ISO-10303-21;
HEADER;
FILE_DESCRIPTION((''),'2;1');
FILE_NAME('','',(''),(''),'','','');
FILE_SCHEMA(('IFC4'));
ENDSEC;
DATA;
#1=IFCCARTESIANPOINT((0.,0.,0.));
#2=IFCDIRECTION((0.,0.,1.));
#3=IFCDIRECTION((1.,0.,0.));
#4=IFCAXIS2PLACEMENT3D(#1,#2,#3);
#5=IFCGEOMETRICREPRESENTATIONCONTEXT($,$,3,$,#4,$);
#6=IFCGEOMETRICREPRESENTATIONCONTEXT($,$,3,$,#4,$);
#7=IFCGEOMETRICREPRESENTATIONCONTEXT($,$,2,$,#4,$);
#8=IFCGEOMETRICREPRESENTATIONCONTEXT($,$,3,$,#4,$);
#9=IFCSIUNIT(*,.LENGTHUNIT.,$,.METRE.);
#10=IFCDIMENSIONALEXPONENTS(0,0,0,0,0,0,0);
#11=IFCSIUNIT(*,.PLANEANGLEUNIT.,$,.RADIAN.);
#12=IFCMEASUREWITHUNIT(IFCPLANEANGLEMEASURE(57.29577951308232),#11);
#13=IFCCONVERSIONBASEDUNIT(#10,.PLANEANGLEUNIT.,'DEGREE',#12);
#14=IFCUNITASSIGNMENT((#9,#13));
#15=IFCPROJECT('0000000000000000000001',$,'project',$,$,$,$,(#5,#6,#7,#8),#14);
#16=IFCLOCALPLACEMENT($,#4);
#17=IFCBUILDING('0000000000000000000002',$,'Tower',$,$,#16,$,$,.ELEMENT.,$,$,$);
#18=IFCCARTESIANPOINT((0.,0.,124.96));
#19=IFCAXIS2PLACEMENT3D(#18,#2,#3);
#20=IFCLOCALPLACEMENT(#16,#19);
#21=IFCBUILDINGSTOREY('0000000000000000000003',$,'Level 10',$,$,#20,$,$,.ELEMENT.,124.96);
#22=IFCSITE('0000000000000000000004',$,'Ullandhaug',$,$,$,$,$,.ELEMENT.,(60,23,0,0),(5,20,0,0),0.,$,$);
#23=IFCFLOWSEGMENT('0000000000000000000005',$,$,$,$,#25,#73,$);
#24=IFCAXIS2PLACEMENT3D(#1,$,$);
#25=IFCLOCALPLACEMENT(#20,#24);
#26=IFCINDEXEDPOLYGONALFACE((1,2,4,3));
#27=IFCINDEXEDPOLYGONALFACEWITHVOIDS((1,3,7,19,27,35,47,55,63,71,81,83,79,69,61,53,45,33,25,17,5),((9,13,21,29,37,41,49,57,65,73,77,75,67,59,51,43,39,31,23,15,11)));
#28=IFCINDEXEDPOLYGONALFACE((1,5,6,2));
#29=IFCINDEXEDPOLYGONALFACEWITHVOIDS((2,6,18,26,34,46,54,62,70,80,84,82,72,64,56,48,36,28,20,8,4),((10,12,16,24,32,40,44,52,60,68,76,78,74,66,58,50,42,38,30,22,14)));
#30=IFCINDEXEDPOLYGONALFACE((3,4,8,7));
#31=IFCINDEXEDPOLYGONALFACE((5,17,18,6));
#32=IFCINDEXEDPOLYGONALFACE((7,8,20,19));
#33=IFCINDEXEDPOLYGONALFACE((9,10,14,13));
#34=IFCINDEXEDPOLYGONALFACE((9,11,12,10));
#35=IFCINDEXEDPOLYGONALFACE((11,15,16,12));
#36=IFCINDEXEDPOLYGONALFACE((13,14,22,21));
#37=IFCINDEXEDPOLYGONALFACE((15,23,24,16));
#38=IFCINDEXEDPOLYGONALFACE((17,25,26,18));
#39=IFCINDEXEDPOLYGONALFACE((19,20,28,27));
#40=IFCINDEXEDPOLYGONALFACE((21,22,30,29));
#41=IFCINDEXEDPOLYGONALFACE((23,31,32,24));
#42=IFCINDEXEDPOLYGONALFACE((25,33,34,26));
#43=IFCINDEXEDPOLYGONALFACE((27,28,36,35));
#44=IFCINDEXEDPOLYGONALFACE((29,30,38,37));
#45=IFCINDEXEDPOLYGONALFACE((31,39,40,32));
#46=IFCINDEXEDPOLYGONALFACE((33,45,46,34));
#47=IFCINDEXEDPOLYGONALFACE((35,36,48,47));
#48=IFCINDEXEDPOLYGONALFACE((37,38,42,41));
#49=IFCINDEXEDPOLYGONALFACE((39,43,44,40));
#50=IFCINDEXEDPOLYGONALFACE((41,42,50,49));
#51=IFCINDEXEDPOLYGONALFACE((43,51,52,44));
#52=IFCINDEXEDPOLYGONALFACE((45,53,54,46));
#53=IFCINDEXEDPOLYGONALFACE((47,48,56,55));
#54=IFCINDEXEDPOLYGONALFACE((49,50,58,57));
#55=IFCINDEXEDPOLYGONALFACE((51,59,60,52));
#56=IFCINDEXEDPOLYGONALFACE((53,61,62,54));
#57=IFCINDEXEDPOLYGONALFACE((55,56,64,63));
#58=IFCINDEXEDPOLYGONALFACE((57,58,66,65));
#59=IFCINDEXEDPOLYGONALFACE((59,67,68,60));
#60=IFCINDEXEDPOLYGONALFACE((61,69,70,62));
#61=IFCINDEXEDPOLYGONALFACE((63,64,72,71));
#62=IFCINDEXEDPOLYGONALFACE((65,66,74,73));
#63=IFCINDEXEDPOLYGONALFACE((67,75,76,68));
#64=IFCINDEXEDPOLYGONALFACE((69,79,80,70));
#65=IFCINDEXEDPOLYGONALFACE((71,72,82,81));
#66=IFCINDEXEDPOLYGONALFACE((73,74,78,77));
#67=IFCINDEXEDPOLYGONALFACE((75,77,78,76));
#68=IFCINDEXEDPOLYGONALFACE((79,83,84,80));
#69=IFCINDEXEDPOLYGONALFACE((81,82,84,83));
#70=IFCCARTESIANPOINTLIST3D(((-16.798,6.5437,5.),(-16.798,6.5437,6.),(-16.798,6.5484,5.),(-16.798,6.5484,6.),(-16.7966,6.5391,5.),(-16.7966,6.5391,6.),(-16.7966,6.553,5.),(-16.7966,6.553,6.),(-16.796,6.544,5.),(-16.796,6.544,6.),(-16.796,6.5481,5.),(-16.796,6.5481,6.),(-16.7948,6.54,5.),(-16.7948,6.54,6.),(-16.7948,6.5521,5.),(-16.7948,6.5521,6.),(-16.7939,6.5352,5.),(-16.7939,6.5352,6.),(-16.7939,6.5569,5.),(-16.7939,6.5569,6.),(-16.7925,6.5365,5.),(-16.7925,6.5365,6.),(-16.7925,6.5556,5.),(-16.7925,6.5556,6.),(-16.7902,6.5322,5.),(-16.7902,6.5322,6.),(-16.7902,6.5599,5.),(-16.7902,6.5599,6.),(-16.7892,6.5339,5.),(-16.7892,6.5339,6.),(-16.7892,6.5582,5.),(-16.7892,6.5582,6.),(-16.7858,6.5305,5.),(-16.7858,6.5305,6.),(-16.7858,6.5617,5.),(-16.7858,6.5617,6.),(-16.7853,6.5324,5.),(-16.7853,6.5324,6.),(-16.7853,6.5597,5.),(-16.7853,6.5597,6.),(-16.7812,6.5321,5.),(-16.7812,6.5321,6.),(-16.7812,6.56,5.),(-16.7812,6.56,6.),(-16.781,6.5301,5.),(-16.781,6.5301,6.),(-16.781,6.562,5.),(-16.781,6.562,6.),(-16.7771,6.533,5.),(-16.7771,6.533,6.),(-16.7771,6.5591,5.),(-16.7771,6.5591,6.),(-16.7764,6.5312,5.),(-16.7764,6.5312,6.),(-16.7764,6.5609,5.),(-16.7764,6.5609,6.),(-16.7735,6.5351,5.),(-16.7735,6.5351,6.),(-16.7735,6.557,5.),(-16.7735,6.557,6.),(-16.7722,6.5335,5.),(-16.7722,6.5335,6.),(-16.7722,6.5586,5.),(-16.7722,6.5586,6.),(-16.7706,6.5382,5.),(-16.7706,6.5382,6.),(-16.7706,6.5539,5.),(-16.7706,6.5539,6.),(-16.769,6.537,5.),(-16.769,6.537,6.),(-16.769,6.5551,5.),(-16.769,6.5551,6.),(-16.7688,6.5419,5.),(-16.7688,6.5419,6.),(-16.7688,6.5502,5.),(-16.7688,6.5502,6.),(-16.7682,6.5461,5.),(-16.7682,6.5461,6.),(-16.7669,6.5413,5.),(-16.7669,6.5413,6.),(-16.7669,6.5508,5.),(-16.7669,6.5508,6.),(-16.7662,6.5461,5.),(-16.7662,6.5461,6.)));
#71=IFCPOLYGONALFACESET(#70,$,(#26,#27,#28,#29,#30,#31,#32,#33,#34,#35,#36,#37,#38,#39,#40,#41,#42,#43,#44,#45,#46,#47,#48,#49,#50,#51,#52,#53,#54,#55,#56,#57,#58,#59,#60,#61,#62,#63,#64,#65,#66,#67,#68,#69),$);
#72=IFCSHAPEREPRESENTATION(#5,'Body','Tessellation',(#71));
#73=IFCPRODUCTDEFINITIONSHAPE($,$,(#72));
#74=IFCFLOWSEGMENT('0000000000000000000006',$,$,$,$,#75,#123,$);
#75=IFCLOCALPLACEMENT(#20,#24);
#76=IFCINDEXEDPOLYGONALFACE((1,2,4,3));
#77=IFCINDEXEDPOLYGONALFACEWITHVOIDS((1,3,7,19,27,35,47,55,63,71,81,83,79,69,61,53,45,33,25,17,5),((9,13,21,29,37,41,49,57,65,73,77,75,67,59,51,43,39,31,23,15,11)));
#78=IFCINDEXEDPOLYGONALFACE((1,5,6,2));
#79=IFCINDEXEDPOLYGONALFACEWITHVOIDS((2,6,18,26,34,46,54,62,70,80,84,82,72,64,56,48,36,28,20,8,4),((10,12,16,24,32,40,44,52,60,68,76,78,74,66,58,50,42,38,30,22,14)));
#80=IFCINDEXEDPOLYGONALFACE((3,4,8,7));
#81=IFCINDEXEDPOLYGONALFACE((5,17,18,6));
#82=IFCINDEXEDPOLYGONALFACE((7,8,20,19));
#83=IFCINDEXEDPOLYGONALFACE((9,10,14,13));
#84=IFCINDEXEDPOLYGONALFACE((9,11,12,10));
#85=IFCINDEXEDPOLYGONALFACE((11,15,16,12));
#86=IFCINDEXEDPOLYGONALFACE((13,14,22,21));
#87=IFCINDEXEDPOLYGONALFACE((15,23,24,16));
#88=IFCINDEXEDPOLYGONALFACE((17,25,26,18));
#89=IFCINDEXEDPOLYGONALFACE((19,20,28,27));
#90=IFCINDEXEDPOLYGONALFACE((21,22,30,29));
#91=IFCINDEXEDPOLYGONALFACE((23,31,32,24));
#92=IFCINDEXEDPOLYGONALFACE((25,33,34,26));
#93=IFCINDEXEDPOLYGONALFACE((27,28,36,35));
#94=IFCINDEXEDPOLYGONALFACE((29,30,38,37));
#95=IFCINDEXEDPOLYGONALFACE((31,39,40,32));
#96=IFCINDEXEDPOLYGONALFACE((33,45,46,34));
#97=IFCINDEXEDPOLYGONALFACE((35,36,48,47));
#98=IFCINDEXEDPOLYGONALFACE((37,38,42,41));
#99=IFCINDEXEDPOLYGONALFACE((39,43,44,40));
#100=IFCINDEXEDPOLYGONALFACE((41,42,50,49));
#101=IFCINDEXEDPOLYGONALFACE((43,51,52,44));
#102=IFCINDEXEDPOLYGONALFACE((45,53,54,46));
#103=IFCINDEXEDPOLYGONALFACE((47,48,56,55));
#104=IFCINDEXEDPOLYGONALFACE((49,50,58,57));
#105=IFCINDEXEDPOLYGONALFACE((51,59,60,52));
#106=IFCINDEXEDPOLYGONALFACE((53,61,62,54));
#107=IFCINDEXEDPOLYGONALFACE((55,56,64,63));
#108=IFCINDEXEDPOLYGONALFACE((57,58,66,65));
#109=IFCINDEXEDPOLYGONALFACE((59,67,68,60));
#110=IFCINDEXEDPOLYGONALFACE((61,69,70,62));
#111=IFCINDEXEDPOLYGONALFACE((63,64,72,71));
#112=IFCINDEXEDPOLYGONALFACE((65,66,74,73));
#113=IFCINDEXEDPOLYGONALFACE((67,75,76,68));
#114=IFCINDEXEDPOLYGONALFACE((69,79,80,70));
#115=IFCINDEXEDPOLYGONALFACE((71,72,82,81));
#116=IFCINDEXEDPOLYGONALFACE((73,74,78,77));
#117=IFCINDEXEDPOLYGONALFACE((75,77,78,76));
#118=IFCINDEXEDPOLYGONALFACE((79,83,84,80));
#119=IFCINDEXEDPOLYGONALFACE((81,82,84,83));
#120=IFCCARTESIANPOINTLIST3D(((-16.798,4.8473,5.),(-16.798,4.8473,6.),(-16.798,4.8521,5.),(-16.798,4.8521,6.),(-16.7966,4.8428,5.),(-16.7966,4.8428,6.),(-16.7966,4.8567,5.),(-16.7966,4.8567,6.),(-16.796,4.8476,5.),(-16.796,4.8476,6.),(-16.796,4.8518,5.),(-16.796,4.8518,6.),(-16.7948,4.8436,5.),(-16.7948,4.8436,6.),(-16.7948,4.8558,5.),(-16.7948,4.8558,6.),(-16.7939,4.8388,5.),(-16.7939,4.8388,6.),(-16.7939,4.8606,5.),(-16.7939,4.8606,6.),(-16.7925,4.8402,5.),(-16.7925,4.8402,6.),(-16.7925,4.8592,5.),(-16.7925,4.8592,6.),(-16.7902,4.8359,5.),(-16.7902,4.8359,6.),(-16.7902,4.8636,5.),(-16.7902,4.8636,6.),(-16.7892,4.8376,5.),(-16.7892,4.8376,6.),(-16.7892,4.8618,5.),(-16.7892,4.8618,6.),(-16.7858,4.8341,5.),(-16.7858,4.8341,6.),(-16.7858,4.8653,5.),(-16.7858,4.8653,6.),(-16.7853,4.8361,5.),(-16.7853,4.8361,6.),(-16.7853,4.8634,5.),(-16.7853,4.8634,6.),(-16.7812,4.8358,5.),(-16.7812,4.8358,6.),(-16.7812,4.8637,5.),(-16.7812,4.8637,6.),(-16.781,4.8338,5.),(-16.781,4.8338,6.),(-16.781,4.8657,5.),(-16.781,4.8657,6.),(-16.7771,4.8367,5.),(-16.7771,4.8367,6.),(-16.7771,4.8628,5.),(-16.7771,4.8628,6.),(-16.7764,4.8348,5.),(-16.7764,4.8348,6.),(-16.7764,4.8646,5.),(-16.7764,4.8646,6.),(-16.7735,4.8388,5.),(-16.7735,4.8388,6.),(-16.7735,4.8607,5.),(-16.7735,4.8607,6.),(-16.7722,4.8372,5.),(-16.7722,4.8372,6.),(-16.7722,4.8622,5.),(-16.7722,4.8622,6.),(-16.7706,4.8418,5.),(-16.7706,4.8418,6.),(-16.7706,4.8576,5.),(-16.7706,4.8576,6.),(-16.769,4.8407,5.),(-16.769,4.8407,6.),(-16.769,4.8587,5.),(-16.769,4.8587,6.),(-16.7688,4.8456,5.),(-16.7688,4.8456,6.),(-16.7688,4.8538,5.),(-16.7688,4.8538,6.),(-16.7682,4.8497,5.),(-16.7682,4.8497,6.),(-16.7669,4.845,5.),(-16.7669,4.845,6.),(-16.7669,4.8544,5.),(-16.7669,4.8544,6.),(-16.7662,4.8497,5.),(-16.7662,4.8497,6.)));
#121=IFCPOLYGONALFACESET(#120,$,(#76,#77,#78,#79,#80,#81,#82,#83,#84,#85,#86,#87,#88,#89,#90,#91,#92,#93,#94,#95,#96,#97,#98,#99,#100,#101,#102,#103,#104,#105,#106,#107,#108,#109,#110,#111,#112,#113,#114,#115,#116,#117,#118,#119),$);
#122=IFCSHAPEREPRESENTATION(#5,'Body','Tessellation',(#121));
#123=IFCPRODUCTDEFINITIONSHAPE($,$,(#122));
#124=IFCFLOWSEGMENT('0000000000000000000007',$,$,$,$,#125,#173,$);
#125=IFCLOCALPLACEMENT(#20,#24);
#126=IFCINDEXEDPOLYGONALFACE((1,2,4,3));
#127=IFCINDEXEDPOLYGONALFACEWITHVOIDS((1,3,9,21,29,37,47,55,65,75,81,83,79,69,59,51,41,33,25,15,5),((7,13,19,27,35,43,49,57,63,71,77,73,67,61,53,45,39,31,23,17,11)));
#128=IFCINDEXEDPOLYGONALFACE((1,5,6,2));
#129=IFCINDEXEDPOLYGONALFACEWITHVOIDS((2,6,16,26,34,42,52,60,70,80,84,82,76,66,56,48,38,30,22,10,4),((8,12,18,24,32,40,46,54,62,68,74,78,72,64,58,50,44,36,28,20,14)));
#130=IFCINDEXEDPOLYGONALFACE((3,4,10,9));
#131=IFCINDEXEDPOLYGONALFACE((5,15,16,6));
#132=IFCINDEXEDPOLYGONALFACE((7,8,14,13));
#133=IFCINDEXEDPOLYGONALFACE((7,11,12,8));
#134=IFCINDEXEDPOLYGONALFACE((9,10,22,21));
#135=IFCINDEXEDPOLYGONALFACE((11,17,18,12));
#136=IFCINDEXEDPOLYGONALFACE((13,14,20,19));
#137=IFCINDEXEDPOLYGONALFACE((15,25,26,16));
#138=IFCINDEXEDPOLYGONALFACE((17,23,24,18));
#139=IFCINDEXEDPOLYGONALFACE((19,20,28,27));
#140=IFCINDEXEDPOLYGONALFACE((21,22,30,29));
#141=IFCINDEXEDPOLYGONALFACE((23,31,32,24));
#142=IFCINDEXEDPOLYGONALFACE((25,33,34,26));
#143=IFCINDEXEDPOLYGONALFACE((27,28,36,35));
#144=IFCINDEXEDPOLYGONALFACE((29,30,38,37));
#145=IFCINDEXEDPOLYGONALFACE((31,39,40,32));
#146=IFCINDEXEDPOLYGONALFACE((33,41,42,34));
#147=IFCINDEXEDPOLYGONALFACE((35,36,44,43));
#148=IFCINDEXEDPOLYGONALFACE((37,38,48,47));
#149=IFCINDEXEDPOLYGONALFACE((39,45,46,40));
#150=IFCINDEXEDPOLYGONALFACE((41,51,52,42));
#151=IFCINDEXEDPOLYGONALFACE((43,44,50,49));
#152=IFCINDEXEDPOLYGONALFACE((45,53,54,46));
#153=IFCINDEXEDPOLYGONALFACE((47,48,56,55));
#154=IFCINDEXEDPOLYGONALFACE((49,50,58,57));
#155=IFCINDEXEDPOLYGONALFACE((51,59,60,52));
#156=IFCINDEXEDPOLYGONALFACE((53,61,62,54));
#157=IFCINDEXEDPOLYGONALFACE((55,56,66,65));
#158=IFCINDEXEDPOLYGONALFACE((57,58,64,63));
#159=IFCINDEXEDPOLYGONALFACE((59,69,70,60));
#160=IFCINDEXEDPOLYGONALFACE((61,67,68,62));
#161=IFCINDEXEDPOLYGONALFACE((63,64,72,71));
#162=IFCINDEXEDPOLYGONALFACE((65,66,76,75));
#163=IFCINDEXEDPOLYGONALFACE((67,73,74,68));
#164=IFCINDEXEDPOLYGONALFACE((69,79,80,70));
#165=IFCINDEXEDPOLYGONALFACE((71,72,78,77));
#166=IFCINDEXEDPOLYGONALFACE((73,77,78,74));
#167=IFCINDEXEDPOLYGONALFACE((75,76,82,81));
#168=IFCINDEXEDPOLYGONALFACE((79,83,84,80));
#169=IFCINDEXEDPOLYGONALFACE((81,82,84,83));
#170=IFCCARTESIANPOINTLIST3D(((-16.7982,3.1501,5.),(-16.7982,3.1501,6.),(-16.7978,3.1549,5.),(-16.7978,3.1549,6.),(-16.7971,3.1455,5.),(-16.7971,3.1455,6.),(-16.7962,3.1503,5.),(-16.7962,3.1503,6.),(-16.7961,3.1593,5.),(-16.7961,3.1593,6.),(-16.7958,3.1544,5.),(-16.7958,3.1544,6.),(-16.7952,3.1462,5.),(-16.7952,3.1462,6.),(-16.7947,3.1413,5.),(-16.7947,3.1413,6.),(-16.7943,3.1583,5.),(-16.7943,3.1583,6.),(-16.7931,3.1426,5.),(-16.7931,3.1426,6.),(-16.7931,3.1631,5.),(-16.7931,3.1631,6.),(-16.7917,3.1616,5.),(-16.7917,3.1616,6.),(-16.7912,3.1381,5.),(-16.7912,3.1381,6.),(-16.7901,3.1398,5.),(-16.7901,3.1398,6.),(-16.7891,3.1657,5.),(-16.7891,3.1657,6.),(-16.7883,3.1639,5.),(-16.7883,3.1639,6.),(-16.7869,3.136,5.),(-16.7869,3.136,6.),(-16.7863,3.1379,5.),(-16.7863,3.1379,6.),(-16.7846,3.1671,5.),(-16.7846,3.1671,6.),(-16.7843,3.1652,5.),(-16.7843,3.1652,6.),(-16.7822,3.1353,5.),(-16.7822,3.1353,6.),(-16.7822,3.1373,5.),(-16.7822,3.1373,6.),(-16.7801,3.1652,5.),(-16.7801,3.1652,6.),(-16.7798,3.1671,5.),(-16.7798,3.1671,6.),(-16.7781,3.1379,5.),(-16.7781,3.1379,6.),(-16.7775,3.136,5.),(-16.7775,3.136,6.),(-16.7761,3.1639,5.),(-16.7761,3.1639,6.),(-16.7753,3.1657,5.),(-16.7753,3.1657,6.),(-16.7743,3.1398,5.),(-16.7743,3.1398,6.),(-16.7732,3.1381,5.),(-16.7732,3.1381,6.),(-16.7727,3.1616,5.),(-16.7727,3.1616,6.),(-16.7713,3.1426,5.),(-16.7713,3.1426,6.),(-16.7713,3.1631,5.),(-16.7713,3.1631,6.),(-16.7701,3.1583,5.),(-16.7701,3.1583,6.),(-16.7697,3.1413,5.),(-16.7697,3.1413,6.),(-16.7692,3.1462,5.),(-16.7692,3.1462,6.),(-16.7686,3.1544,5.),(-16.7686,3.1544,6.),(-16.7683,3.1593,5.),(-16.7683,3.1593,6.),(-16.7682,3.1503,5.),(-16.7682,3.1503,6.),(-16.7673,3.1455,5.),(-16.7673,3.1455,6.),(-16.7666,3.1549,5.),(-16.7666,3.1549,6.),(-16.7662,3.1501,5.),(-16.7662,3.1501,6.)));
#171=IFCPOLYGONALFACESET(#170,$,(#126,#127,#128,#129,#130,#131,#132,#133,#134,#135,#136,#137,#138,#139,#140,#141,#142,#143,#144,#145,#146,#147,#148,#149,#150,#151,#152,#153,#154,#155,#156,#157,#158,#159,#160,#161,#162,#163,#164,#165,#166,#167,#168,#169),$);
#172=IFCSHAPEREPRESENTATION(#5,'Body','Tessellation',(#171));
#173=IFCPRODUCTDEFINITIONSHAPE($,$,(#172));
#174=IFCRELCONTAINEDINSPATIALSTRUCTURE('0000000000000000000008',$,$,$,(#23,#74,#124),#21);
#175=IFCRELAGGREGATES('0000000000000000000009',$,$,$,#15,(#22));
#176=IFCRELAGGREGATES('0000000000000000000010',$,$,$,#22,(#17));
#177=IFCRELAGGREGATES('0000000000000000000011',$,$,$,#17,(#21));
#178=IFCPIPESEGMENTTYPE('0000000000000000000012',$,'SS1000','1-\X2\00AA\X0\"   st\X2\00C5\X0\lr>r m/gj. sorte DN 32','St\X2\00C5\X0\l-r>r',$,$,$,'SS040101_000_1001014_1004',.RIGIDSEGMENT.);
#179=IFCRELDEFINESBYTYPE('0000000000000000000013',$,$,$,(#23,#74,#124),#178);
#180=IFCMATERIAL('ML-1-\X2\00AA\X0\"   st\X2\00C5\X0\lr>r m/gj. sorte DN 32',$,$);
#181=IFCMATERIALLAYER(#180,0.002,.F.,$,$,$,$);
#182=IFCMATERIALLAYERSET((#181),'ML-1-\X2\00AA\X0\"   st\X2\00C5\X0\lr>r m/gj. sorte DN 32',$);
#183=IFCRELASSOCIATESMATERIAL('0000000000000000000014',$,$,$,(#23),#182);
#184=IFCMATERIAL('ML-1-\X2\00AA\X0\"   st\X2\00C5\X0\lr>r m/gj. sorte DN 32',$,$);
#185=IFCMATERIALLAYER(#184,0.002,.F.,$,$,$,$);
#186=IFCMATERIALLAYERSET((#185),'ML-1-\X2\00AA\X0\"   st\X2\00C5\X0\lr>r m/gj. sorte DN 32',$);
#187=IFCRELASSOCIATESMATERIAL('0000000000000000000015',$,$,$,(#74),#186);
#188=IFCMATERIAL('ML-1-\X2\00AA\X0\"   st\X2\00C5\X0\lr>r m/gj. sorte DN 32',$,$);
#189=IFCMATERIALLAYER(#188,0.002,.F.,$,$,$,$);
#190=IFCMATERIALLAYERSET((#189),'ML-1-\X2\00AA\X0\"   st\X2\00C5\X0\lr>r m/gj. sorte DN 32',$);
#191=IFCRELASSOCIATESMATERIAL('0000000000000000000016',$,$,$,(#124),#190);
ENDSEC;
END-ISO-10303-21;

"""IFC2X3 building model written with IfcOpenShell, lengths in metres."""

from ifc_helpers import new_model, entity, si_unit, converted_unit, frame, origin_with_axes, origin_2d_with_axis, place, context, project, spatial, hollow_circle, extrude, material, layer, layer_set, layer_usage, type_object, element, save


model = new_model("IFC2X3")

# Units and contexts
context_of_model_1 = context(None, 3, world=origin_with_axes())
context_of_model_2 = context(None, 3, world=origin_with_axes())
context_of_model_3 = context(None, 2, world=origin_with_axes())
context_of_model_4 = context(None, 3, world=origin_with_axes())
ifc_project = project(units=[si_unit("LENGTHUNIT", "METRE"), converted_unit("PLANEANGLEUNIT", "DEGREE", entity("IfcPlaneAngleMeasure", 57.29577951308232), si_unit("PLANEANGLEUNIT", "RADIAN"), dimensions=[0, 0, 0, 0, 0, 0, 0])], contexts=[context_of_model_1, context_of_model_2, context_of_model_3, context_of_model_4])

# Site, building, storey
site = spatial("IfcSite", under=ifc_project, Name="Ullandhaug", CompositionType="ELEMENT", RefLatitude=(60, 23, 0, 0), RefLongitude=(5, 20, 0, 0), RefElevation=0.0)
building_placement = place(None, origin_with_axes())
building = spatial("IfcBuilding", under=site, at=building_placement, Name="Tower", CompositionType="ELEMENT")
storey_placement = place(building_placement, frame((0.0, 0.0, 124.96), z_axis=(0.0, 0.0, 1.0), x_axis=(1.0, 0.0, 0.0)))
storey = spatial("IfcBuildingStorey", under=building, at=storey_placement, Name="Level 10", CompositionType="ELEMENT", Elevation=124.96)

# Flow segments
pipe_segment_type_1 = type_object("IfcPipeSegmentType", Name="SS1000", Description="1-ª\"   stÅlr>r m/gj. sorte DN 32", ApplicableOccurrence="StÅl-r>r", ElementType="SS040101_000_1001014_1004", PredefinedType="RIGIDSEGMENT")
ifc_material_1 = material(Name="ML-1-ª\"   stÅlr>r m/gj. sorte DN 32")
ifc_layer_1 = layer(ifc_material_1, 0.002, ventilated=False)
ifc_layer_set_1 = layer_set([ifc_layer_1], Name="ML-1-ª\"   stÅlr>r m/gj. sorte DN 32")
ifc_layer_usage_1 = layer_usage(ifc_layer_set_1, "AXIS2", "POSITIVE", 0.0)
flow_segment_1_placement = place(storey_placement, frame((-16.7822, 6.5461, 5.0), z_axis=(0.0, 0.0, 1.0), x_axis=(1.0, 0.0, 0.0)))
element("IfcFlowSegment", 1, at=flow_segment_1_placement, inside=storey, type_object=pipe_segment_type_1, material=ifc_layer_usage_1, context=context_of_model_1, shape_type="SweptSolid", body=[
    extrude(hollow_circle(Radius=0.016, WallThickness=0.002, at=origin_2d_with_axis()), origin_with_axes(), (0.0, 0.0, 1.0), 1.0),
])
ifc_material_2 = material(Name="ML-1-ª\"   stÅlr>r m/gj. sorte DN 32")
ifc_layer_2 = layer(ifc_material_2, 0.002, ventilated=False)
ifc_layer_set_2 = layer_set([ifc_layer_2], Name="ML-1-ª\"   stÅlr>r m/gj. sorte DN 32")
ifc_layer_usage_2 = layer_usage(ifc_layer_set_2, "AXIS2", "POSITIVE", 0.0)
flow_segment_2_placement = place(storey_placement, frame((-16.7822, 4.8497, 5.0), z_axis=(0.0, 0.0, 1.0), x_axis=(1.0, 0.0, 0.0)))
element("IfcFlowSegment", 2, at=flow_segment_2_placement, inside=storey, type_object=pipe_segment_type_1, material=ifc_layer_usage_2, context=context_of_model_1, shape_type="SweptSolid", body=[
    extrude(hollow_circle(Radius=0.016, WallThickness=0.002, at=origin_2d_with_axis()), origin_with_axes(), (0.0, 0.0, 1.0), 1.0),
])
ifc_material_3 = material(Name="ML-1-ª\"   stÅlr>r m/gj. sorte DN 32")
ifc_layer_3 = layer(ifc_material_3, 0.002, ventilated=False)
ifc_layer_set_3 = layer_set([ifc_layer_3], Name="ML-1-ª\"   stÅlr>r m/gj. sorte DN 32")
ifc_layer_usage_3 = layer_usage(ifc_layer_set_3, "AXIS2", "POSITIVE", 0.0)
flow_segment_3_placement = place(storey_placement, frame((-16.7822, 3.1513, 5.0), z_axis=(0.0, 0.0, 1.0), x_axis=(0.0, -1.0, 0.0)))
element("IfcFlowSegment", 3, at=flow_segment_3_placement, inside=storey, type_object=pipe_segment_type_1, material=ifc_layer_usage_3, context=context_of_model_1, shape_type="SweptSolid", body=[
    extrude(hollow_circle(Radius=0.016, WallThickness=0.002, at=origin_2d_with_axis()), origin_with_axes(), (0.0, 0.0, 1.0), 1.0),
])

save(model, "model.ifc")
